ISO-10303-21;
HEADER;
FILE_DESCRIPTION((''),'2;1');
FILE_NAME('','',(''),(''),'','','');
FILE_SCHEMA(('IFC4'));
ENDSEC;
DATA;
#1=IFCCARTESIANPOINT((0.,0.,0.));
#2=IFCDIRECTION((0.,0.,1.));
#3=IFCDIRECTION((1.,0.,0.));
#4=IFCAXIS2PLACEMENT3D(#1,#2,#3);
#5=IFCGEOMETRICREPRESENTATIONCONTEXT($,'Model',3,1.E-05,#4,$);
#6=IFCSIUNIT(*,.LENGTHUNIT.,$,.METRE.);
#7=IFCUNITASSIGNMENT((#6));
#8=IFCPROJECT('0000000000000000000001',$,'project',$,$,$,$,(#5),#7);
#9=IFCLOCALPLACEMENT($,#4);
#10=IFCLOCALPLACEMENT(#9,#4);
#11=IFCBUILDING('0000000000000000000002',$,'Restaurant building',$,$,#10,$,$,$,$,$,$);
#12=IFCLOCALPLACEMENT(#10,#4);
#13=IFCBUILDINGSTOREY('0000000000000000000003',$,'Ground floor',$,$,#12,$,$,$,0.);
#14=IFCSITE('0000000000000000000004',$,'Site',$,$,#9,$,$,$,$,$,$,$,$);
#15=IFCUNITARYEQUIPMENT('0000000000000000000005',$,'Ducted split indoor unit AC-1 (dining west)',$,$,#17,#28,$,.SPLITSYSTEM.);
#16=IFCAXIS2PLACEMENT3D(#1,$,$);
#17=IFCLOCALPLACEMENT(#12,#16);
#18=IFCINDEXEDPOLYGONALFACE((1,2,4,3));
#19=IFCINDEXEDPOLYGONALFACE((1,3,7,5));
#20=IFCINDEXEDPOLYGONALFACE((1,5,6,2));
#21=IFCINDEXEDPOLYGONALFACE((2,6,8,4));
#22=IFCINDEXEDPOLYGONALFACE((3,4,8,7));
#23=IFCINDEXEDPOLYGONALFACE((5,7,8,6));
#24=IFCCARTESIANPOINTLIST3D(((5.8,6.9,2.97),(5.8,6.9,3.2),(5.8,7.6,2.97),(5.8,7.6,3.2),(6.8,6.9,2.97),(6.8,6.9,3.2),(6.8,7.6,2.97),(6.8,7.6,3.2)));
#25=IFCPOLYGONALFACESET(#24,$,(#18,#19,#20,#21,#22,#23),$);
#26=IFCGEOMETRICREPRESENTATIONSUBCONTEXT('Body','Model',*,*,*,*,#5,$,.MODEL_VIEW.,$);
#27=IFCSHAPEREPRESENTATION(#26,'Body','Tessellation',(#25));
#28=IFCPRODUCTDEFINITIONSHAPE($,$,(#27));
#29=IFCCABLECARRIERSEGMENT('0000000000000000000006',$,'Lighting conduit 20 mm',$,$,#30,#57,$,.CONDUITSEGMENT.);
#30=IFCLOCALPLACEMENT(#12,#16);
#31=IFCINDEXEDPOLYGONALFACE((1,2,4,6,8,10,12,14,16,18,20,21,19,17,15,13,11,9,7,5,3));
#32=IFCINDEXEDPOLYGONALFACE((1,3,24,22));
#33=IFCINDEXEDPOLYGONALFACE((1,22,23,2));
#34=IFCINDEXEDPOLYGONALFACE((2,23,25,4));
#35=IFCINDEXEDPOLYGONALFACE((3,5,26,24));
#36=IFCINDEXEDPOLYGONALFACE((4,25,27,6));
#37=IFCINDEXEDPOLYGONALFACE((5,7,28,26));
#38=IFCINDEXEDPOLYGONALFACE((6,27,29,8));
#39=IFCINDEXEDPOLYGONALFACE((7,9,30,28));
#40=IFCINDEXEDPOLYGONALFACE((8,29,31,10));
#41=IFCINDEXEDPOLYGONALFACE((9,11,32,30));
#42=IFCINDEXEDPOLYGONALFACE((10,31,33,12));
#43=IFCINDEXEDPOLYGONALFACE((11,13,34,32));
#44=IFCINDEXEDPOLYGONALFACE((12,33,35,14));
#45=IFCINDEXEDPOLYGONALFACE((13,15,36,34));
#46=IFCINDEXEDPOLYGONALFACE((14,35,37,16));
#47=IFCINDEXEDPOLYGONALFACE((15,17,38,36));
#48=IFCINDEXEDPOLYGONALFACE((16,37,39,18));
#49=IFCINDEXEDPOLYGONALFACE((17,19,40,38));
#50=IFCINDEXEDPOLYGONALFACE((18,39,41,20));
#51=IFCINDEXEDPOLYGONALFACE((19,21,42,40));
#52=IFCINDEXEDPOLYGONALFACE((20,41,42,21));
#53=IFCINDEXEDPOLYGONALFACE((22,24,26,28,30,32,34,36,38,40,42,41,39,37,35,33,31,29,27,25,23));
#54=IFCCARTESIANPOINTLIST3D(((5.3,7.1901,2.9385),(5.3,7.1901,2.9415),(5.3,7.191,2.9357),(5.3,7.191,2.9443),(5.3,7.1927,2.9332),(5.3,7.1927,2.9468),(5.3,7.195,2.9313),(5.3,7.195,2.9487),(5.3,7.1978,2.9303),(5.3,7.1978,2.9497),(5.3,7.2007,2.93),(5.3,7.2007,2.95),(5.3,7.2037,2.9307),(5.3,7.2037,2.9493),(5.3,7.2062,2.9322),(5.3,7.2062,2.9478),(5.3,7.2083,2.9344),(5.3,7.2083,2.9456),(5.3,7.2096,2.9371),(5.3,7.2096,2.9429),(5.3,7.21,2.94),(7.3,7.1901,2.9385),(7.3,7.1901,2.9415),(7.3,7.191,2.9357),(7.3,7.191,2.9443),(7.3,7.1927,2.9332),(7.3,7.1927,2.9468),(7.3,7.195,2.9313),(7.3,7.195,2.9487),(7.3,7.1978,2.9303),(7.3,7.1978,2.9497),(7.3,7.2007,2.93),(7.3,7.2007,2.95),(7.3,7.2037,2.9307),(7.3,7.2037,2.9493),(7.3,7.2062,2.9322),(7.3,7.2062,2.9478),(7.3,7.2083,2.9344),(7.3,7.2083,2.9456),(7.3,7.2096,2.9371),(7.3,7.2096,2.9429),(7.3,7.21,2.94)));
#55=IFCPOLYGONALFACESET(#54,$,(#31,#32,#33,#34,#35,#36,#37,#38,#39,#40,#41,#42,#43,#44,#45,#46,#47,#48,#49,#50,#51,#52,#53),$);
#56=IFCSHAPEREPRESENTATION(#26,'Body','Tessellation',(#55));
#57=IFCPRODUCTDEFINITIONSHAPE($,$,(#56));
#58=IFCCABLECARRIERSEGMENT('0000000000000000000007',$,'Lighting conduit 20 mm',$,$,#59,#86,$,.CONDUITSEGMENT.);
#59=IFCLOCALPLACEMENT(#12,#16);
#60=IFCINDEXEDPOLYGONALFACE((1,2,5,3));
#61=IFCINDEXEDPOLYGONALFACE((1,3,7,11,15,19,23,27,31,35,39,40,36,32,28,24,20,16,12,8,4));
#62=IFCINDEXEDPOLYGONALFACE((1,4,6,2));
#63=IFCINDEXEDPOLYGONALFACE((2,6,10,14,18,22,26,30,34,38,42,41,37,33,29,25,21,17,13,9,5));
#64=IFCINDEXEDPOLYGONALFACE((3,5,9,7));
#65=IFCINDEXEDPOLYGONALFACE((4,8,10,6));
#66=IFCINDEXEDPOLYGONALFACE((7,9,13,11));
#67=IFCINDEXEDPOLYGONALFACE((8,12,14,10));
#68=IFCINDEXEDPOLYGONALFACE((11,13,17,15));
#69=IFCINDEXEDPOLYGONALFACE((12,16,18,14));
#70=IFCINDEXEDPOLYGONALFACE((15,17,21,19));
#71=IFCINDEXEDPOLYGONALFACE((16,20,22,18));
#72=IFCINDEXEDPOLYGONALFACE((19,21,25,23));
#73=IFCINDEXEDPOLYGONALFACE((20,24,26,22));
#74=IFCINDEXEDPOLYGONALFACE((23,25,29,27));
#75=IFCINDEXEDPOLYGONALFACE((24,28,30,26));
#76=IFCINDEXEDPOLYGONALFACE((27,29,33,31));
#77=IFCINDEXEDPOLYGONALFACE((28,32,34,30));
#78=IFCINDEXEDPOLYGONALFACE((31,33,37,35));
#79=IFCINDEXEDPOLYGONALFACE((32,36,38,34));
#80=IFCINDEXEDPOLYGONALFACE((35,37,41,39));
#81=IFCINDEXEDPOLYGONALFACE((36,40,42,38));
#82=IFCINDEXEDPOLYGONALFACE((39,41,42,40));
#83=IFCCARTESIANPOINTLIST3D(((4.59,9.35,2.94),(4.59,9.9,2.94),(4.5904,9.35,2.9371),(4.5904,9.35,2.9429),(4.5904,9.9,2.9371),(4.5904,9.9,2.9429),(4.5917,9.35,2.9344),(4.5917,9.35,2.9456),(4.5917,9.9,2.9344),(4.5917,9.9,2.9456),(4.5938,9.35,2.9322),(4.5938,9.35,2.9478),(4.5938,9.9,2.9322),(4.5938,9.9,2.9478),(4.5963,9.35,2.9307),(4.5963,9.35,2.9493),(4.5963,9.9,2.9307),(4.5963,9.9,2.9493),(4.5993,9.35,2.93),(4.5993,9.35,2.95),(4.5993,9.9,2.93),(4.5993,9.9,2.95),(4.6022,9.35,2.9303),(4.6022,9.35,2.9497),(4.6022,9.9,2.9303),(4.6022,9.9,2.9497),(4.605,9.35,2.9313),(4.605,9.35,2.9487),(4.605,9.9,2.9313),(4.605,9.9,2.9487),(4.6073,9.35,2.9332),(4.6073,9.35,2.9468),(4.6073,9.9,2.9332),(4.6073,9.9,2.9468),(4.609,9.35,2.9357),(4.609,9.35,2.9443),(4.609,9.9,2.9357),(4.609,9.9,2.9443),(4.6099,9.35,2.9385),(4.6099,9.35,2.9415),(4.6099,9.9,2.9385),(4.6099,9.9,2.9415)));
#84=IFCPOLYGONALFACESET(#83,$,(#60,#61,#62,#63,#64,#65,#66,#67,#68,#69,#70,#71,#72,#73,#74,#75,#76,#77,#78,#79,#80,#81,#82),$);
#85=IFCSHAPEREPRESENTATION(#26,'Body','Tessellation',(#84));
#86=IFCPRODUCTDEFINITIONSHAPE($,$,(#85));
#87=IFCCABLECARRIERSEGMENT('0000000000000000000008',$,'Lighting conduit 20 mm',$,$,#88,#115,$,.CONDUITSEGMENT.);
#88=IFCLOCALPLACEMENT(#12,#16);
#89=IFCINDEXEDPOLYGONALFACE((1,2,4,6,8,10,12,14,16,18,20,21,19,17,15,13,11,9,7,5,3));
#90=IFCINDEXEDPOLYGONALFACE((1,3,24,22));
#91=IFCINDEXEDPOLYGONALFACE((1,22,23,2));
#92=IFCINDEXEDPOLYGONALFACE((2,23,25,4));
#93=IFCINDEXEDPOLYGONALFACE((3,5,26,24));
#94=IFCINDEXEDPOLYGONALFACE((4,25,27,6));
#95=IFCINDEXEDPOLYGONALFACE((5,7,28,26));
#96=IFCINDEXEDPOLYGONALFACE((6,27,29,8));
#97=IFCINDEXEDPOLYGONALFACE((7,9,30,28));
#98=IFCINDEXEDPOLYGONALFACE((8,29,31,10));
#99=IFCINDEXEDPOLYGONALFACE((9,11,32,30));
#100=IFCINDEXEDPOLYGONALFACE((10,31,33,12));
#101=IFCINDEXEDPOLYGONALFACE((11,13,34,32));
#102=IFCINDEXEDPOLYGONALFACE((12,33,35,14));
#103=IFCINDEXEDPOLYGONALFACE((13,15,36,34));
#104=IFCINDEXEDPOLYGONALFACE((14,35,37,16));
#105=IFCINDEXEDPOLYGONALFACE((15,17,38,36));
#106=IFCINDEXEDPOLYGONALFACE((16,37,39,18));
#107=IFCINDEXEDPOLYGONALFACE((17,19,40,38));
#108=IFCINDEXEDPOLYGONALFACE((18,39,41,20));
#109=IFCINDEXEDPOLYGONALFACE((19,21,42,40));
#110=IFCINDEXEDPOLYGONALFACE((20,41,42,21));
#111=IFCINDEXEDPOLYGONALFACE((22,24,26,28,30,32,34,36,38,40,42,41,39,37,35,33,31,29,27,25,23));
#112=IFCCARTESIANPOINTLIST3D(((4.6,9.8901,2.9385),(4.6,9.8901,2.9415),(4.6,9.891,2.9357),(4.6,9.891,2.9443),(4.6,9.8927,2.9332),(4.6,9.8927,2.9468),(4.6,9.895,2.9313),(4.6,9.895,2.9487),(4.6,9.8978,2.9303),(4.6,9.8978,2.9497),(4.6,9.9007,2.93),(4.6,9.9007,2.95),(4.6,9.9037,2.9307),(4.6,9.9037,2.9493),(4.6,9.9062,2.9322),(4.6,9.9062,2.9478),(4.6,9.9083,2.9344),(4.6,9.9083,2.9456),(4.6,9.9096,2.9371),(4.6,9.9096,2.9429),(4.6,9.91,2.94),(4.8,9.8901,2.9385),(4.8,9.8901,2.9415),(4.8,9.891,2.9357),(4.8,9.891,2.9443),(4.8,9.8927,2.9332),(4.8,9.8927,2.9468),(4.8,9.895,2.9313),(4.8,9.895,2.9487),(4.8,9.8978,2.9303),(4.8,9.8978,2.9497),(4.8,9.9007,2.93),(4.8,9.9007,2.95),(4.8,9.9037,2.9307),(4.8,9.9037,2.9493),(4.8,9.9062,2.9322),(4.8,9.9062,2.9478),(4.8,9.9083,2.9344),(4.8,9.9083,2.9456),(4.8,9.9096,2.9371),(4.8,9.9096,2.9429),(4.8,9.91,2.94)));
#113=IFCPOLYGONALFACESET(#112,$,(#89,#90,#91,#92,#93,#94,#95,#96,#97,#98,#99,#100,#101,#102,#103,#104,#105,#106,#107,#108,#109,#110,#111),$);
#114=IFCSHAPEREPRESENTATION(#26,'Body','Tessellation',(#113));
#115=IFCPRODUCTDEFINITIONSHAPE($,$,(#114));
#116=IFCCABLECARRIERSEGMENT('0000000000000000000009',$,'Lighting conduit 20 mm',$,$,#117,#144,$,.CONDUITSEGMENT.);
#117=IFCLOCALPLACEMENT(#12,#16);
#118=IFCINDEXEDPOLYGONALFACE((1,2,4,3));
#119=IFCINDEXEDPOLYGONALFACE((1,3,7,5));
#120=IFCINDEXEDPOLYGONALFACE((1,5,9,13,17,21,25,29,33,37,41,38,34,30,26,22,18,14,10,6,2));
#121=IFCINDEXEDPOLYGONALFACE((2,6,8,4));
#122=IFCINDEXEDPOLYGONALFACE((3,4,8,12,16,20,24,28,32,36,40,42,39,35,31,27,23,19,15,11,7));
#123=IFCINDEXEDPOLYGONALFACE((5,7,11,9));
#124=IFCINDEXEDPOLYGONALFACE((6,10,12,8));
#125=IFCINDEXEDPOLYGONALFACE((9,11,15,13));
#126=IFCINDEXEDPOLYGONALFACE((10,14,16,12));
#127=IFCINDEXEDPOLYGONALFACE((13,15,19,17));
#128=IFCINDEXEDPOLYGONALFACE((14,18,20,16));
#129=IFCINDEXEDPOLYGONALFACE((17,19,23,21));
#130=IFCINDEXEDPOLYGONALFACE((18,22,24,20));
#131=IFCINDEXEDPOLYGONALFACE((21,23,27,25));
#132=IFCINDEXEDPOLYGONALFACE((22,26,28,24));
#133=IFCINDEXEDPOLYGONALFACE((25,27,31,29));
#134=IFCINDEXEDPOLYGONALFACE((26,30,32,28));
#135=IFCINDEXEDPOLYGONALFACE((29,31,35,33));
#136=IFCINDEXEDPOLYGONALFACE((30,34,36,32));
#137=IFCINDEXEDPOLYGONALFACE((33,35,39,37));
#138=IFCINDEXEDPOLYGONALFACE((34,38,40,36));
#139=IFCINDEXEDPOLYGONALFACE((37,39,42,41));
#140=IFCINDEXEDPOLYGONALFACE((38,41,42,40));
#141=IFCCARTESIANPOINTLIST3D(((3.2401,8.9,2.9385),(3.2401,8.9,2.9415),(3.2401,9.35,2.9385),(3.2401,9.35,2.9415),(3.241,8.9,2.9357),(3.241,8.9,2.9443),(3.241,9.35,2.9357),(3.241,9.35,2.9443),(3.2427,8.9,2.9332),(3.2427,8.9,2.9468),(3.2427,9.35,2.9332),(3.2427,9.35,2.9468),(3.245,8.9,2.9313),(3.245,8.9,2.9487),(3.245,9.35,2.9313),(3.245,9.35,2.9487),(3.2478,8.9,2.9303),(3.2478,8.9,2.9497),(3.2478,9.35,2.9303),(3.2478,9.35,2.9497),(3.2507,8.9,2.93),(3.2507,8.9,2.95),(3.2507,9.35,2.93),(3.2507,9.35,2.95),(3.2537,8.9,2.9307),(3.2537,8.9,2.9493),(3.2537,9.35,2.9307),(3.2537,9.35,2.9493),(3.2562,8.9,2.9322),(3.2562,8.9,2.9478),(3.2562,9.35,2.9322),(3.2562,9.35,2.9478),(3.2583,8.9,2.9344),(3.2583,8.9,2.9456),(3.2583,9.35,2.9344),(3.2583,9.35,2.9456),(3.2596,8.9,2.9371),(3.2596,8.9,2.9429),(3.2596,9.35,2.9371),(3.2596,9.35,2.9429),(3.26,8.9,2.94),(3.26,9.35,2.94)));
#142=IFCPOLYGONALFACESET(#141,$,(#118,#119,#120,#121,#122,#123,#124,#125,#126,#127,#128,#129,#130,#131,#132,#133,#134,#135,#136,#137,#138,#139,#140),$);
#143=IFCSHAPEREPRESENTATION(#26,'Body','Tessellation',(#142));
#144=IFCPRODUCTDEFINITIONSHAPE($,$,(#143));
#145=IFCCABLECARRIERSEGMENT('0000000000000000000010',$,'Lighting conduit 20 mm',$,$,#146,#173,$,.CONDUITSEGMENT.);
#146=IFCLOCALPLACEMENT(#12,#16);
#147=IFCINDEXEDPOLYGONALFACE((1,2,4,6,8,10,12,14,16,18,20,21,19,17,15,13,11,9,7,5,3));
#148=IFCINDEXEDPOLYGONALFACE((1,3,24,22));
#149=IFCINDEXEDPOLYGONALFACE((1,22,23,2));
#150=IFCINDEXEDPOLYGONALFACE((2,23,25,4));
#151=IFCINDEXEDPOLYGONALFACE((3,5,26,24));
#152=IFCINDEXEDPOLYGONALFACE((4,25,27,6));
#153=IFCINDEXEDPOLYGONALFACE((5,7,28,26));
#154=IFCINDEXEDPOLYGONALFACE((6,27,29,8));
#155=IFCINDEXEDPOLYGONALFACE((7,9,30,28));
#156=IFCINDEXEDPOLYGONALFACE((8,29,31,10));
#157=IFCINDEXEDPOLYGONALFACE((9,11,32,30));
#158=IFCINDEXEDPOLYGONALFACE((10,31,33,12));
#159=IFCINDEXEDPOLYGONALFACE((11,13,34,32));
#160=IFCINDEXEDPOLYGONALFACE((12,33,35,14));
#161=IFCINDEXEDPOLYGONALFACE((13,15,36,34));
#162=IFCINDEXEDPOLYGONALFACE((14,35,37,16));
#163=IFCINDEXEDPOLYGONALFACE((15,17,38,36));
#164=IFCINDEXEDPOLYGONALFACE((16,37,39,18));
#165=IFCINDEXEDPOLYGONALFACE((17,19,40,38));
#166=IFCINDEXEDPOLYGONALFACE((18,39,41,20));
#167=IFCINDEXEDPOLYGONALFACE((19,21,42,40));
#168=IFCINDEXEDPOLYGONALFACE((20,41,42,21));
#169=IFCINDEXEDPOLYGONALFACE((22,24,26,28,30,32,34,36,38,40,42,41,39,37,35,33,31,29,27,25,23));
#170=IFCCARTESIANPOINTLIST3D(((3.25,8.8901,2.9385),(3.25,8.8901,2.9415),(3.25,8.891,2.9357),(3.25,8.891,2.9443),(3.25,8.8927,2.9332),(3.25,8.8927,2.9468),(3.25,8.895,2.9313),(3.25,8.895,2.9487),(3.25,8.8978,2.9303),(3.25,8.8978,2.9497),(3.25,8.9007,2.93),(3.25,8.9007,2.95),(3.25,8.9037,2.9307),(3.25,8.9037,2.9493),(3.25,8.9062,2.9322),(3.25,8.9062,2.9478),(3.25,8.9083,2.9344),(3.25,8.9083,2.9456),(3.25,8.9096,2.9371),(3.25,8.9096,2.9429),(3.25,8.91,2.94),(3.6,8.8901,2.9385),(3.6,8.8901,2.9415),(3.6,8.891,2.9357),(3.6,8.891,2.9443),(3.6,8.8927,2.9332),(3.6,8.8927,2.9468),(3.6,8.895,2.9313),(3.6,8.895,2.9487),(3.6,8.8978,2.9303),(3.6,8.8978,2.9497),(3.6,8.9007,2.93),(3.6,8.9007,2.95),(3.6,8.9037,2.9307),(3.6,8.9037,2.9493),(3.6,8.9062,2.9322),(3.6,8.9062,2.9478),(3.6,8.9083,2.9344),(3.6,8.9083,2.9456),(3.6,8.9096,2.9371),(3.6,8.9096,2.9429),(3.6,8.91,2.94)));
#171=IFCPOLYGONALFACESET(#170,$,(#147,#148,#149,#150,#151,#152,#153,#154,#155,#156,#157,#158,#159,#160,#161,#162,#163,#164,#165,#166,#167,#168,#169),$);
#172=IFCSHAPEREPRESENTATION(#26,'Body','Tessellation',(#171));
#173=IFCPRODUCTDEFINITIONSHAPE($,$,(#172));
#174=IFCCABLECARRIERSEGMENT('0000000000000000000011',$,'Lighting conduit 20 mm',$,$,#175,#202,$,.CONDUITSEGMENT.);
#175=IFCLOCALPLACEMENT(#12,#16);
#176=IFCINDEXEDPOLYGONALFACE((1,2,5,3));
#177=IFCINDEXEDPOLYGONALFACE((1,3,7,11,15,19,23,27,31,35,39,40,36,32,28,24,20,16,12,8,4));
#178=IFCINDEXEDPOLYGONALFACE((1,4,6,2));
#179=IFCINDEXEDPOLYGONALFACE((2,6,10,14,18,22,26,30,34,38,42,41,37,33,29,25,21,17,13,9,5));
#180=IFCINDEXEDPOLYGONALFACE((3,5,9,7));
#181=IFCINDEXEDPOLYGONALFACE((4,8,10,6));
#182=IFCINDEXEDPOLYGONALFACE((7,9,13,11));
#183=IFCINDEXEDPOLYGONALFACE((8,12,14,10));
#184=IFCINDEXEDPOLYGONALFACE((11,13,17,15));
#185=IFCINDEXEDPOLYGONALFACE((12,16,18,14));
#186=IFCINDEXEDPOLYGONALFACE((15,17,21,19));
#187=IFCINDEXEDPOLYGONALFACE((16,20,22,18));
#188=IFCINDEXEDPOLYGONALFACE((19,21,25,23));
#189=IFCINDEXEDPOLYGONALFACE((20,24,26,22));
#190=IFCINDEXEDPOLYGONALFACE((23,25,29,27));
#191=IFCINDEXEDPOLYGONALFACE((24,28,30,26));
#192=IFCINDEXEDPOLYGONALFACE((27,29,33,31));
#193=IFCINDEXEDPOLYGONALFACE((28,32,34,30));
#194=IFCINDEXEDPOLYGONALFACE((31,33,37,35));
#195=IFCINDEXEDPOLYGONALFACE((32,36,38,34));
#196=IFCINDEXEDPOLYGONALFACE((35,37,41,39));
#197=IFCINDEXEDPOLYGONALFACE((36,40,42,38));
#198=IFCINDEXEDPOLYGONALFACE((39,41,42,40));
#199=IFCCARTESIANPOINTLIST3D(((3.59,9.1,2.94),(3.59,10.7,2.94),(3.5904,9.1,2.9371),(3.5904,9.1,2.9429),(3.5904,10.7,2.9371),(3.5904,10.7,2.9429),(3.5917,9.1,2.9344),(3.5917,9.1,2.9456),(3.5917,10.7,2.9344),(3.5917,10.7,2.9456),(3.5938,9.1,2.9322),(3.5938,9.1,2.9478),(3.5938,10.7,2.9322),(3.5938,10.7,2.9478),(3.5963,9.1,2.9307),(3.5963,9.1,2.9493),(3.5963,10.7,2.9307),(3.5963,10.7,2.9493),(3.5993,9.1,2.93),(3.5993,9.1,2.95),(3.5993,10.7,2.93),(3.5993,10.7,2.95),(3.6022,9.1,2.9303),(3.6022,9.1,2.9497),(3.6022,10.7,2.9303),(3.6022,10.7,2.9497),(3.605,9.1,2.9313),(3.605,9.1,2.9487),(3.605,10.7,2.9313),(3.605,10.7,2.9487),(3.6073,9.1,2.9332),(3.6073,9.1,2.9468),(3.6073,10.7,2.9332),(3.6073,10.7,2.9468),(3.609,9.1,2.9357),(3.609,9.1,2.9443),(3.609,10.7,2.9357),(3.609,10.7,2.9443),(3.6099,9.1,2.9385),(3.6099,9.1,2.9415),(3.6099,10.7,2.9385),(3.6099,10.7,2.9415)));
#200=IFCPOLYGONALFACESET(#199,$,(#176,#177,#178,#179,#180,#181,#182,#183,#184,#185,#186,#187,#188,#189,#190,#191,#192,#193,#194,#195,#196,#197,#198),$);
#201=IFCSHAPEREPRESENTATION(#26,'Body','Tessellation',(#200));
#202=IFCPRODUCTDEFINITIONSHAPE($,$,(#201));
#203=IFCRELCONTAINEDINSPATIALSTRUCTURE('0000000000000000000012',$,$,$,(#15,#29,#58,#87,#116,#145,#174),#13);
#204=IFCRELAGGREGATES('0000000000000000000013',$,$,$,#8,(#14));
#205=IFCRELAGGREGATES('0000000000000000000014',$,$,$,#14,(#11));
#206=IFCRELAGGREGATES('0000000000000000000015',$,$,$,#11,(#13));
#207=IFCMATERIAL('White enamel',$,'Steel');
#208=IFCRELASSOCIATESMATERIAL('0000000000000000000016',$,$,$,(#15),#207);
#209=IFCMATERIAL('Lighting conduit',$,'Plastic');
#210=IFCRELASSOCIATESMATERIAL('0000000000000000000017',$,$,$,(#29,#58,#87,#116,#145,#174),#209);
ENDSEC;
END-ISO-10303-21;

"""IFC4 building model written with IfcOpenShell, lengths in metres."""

from ifc_helpers import new_model, si_unit, frame, origin_with_axes, origin_2d, place, context, subcontext, project, spatial, rectangle, circle, extrude, material, element, save


model = new_model("IFC4")

# Units and contexts
model_context = context("Model", 3, precision=1e-05, world=origin_with_axes())
body_context = subcontext(model_context, "Body", "Model", "MODEL_VIEW")
ifc_project = project(units=[si_unit("LENGTHUNIT", "METRE")], contexts=[model_context])

# Site, building, storey
site_placement = place(None, origin_with_axes())
site = spatial("IfcSite", under=ifc_project, at=site_placement, Name="Site")
building_placement = place(site_placement, origin_with_axes())
building = spatial("IfcBuilding", under=site, at=building_placement, Name="Restaurant building")
storey_placement = place(building_placement, origin_with_axes())
storey = spatial("IfcBuildingStorey", under=building, at=storey_placement, Name="Ground floor", Elevation=0.0)

# Shared definitions
ifc_material_1 = material(Name="White enamel", Category="Steel")

# Unitary equipment
unitary_equipment_placement = place(storey_placement, frame((6.3, 7.25, 0.0)))
element("IfcUnitaryEquipment", 1, at=unitary_equipment_placement, inside=storey, material=ifc_material_1, Name="Ducted split indoor unit AC-1 (dining west)", PredefinedType="SPLITSYSTEM", context=body_context, shape_type="SweptSolid", body=[
    extrude(rectangle(XDim=1.0, YDim=0.7, at=origin_2d()), frame((0.0, 0.0, 2.97)), (0.0, 0.0, 1.0), 0.23),
])

# Cable carrier segments
ifc_material_2 = material(Name="Lighting conduit", Category="Plastic")
cable_carrier_segment_1_placement = place(storey_placement, frame((5.3, 7.2, 2.94)))
element("IfcCableCarrierSegment", 2, at=cable_carrier_segment_1_placement, inside=storey, material=ifc_material_2, Name="Lighting conduit 20 mm", PredefinedType="CONDUITSEGMENT", context=body_context, shape_type="SweptSolid", body=[
    extrude(circle(Radius=0.01, at=origin_2d()), frame((0.0, 0.0, 0.0), z_axis=(1.0, 0.0, 0.0), x_axis=(0.0, 1.0, 0.0)), (0.0, 0.0, 1.0), 2.0),
])
cable_carrier_segment_2_placement = place(storey_placement, frame((4.6, 9.35, 2.94)))
element("IfcCableCarrierSegment", 3, at=cable_carrier_segment_2_placement, inside=storey, material=ifc_material_2, Name="Lighting conduit 20 mm", PredefinedType="CONDUITSEGMENT", context=body_context, shape_type="SweptSolid", body=[
    extrude(circle(Radius=0.01, at=origin_2d()), frame((0.0, 0.0, 0.0), z_axis=(0.0, 1.0, 0.0), x_axis=(-1.0, 0.0, 0.0)), (0.0, 0.0, 1.0), 0.55),
])
cable_carrier_segment_3_placement = place(storey_placement, frame((4.6, 9.9, 2.94)))
element("IfcCableCarrierSegment", 4, at=cable_carrier_segment_3_placement, inside=storey, material=ifc_material_2, Name="Lighting conduit 20 mm", PredefinedType="CONDUITSEGMENT", context=body_context, shape_type="SweptSolid", body=[
    extrude(circle(Radius=0.01, at=origin_2d()), frame((0.0, 0.0, 0.0), z_axis=(1.0, 0.0, 0.0), x_axis=(0.0, 1.0, 0.0)), (0.0, 0.0, 1.0), 0.2),
])
cable_carrier_segment_4_placement = place(storey_placement, frame((3.25, 9.35, 2.94)))
element("IfcCableCarrierSegment", 5, at=cable_carrier_segment_4_placement, inside=storey, material=ifc_material_2, Name="Lighting conduit 20 mm", PredefinedType="CONDUITSEGMENT", context=body_context, shape_type="SweptSolid", body=[
    extrude(circle(Radius=0.01, at=origin_2d()), frame((0.0, 0.0, 0.0), z_axis=(0.0, -1.0, 0.0), x_axis=(1.0, 0.0, 0.0)), (0.0, 0.0, 1.0), 0.45),
])
cable_carrier_segment_5_placement = place(storey_placement, frame((3.25, 8.9, 2.94)))
element("IfcCableCarrierSegment", 6, at=cable_carrier_segment_5_placement, inside=storey, material=ifc_material_2, Name="Lighting conduit 20 mm", PredefinedType="CONDUITSEGMENT", context=body_context, shape_type="SweptSolid", body=[
    extrude(circle(Radius=0.01, at=origin_2d()), frame((0.0, 0.0, 0.0), z_axis=(1.0, 0.0, 0.0), x_axis=(0.0, 1.0, 0.0)), (0.0, 0.0, 1.0), 0.35),
])
cable_carrier_segment_6_placement = place(storey_placement, frame((3.6, 9.1, 2.94)))
element("IfcCableCarrierSegment", 7, at=cable_carrier_segment_6_placement, inside=storey, material=ifc_material_2, Name="Lighting conduit 20 mm", PredefinedType="CONDUITSEGMENT", context=body_context, shape_type="SweptSolid", body=[
    extrude(circle(Radius=0.01, at=origin_2d()), frame((0.0, 0.0, 0.0), z_axis=(0.0, 1.0, 0.0), x_axis=(-1.0, 0.0, 0.0)), (0.0, 0.0, 1.0), 1.6),
])

save(model, "model.ifc")
